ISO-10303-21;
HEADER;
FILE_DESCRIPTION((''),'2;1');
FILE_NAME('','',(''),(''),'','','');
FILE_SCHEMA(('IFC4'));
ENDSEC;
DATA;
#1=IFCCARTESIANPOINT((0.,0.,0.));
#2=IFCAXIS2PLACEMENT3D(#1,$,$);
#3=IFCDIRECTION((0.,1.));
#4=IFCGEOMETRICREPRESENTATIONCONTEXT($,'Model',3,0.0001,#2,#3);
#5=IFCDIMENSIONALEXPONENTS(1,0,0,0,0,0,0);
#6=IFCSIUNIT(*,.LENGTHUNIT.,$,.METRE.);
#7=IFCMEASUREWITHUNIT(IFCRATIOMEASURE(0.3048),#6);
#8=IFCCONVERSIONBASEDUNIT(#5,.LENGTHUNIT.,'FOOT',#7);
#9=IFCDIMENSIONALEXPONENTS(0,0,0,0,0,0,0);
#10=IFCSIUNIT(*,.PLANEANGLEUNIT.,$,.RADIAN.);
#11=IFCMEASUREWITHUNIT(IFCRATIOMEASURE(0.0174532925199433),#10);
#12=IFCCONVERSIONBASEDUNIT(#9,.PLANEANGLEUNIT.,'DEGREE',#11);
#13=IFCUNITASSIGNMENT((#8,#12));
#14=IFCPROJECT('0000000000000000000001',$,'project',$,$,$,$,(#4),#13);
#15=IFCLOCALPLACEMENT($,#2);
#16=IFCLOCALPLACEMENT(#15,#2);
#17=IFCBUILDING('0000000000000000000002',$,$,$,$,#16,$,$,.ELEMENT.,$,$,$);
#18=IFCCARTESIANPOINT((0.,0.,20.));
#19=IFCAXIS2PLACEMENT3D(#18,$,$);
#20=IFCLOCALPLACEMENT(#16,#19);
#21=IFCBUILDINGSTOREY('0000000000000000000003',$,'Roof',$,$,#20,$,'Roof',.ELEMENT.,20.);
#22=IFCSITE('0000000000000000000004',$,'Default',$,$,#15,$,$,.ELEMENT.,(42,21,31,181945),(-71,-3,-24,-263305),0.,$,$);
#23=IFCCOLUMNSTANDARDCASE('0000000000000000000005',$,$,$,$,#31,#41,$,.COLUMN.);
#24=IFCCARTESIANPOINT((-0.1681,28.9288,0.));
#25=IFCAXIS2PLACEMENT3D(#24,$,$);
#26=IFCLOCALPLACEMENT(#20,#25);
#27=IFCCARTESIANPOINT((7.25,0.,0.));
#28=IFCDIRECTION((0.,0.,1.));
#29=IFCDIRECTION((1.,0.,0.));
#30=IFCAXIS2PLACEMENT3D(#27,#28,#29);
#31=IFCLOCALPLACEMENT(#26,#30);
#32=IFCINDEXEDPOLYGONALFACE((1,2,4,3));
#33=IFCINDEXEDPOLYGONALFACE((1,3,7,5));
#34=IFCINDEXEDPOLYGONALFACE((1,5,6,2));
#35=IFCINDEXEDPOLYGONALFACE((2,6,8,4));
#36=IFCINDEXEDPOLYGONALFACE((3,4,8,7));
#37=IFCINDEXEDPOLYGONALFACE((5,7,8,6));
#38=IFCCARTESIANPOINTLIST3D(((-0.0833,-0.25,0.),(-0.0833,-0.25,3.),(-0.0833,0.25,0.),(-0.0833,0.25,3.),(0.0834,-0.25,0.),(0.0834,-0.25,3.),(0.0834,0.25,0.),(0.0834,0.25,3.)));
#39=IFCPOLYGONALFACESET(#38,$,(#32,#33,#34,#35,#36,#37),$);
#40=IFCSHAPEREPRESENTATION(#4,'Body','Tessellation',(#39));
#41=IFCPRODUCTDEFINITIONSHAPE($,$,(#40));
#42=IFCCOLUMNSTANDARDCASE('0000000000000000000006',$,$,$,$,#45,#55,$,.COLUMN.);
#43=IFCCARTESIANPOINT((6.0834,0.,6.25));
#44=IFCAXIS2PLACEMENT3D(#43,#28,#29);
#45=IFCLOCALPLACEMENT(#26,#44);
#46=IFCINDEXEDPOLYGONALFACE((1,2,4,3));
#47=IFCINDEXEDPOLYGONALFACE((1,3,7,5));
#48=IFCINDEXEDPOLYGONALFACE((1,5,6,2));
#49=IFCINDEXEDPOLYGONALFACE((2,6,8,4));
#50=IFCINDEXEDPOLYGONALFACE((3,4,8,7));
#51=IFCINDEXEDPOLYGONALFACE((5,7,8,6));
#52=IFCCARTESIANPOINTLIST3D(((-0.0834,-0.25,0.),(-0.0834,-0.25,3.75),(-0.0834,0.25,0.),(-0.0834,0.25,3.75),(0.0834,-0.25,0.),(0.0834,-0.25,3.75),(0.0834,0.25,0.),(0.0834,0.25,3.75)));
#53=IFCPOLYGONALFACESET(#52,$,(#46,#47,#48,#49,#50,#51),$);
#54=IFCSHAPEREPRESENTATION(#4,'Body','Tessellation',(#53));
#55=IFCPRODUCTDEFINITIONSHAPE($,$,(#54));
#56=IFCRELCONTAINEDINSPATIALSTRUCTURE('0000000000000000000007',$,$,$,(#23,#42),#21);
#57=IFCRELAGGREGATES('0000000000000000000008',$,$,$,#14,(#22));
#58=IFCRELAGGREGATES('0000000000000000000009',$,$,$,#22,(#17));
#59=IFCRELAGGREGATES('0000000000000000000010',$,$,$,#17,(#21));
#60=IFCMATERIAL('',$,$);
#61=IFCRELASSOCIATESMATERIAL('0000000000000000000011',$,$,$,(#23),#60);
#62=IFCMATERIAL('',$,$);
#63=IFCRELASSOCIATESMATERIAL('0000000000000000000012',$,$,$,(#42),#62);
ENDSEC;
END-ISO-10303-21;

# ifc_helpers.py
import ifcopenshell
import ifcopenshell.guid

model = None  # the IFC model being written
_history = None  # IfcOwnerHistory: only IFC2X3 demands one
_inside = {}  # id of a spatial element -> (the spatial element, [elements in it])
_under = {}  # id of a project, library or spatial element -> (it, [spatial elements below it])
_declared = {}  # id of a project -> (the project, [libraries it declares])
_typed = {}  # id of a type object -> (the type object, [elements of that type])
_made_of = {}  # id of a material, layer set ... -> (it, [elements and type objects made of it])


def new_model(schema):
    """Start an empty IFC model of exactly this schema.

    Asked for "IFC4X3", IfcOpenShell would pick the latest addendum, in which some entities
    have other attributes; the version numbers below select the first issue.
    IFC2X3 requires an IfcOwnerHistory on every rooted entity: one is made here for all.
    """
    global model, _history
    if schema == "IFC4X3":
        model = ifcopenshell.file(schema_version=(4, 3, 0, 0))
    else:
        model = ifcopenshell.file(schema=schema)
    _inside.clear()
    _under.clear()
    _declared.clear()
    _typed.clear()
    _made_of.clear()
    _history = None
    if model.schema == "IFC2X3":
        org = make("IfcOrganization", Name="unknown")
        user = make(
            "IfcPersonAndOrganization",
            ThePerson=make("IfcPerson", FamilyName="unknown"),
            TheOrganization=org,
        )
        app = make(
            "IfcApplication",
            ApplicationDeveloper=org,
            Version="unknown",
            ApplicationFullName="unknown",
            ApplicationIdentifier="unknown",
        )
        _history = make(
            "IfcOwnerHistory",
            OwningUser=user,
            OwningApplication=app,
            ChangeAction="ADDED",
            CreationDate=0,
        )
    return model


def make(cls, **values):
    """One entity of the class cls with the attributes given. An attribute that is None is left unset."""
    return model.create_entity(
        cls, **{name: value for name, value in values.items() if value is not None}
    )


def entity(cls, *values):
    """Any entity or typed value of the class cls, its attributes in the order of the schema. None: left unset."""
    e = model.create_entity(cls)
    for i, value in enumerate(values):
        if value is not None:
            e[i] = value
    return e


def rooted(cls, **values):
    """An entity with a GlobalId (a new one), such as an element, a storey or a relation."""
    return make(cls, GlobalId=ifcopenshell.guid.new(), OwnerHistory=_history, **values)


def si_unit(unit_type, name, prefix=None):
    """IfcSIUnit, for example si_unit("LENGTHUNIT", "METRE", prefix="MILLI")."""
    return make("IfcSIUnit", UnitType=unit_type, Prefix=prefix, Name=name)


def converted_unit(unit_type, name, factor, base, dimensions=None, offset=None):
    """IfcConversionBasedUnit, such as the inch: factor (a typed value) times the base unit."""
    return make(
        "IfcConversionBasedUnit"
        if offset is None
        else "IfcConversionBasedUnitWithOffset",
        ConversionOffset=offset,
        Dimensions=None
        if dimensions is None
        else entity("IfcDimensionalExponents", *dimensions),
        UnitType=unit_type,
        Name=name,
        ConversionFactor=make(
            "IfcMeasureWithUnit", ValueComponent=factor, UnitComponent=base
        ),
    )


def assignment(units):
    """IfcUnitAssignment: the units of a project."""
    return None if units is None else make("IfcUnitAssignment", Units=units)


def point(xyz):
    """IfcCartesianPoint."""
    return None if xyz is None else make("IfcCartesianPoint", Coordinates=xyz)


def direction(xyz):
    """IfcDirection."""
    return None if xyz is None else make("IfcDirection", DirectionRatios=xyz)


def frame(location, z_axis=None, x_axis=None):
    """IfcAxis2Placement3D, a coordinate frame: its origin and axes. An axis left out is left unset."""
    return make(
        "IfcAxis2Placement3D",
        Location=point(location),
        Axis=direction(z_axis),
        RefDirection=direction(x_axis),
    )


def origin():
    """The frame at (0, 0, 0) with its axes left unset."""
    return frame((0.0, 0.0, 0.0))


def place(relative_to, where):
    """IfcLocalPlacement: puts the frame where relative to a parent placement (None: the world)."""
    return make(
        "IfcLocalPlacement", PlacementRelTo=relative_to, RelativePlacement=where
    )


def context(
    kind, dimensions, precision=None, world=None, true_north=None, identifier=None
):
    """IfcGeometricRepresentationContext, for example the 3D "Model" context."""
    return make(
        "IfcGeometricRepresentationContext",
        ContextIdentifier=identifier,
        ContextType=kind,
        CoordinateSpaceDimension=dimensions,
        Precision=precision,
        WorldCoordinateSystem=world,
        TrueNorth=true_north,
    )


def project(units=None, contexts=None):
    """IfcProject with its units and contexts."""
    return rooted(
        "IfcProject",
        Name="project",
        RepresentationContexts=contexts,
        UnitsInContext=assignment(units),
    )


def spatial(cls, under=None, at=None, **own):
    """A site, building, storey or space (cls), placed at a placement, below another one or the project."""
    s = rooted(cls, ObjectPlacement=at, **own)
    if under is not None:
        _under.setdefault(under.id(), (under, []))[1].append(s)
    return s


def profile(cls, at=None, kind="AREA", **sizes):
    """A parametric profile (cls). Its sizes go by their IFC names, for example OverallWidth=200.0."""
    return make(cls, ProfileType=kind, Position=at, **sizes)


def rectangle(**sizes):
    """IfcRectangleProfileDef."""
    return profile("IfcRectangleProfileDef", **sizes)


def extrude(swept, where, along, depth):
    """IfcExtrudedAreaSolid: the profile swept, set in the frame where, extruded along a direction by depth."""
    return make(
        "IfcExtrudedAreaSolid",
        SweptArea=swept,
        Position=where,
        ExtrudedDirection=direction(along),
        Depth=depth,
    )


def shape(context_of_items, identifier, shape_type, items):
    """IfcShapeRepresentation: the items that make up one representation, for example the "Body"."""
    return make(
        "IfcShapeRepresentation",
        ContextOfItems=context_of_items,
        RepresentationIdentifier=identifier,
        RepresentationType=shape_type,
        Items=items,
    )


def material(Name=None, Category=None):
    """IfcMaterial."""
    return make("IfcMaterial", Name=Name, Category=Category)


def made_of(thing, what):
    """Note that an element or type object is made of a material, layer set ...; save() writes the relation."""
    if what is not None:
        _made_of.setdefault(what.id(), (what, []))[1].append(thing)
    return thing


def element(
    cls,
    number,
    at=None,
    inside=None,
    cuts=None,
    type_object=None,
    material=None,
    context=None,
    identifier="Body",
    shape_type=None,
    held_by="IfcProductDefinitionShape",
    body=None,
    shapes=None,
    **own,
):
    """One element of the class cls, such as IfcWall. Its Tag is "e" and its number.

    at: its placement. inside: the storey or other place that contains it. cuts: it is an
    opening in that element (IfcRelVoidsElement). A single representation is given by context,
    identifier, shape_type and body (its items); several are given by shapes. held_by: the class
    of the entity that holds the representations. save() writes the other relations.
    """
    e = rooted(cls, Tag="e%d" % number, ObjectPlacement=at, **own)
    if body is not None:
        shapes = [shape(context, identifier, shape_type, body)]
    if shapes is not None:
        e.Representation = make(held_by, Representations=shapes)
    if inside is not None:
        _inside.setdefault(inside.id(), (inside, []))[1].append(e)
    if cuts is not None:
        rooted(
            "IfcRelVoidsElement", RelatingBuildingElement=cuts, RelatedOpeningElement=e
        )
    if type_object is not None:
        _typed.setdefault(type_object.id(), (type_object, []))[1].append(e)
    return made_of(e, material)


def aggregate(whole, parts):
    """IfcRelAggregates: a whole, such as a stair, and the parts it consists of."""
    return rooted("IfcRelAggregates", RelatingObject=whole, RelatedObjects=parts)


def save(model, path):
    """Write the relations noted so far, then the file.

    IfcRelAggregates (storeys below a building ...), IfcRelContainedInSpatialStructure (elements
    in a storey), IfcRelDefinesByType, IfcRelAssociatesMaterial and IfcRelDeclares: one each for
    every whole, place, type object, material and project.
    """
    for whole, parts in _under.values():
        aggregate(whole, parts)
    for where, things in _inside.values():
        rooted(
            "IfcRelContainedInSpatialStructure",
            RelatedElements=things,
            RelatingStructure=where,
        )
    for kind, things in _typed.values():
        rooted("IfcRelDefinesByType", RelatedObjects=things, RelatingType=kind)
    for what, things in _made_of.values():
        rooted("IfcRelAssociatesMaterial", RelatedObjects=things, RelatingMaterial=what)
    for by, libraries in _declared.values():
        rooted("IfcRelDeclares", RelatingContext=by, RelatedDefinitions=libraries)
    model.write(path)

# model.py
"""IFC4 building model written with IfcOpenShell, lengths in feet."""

from ifc_helpers import new_model, entity, si_unit, converted_unit, direction, frame, origin, place, context, project, spatial, rectangle, extrude, material, element, save


model = new_model("IFC4")

# Units and contexts
model_context = context("Model", 3, precision=0.0001, world=origin(), true_north=direction((0.0, 1.0)))
ifc_project = project(units=[converted_unit("LENGTHUNIT", "FOOT", entity("IfcRatioMeasure", 0.3048), si_unit("LENGTHUNIT", "METRE"), dimensions=[1, 0, 0, 0, 0, 0, 0]), converted_unit("PLANEANGLEUNIT", "DEGREE", entity("IfcRatioMeasure", 0.0174532925199433), si_unit("PLANEANGLEUNIT", "RADIAN"), dimensions=[0, 0, 0, 0, 0, 0, 0])], contexts=[model_context])

# Site, building, storey
site_placement = place(None, origin())
site = spatial("IfcSite", under=ifc_project, at=site_placement, Name="Default", CompositionType="ELEMENT", RefLatitude=(42, 21, 31, 181945), RefLongitude=(-71, -3, -24, -263305), RefElevation=0.0)
building_placement = place(site_placement, origin())
building = spatial("IfcBuilding", under=site, at=building_placement, CompositionType="ELEMENT")
storey_placement = place(building_placement, frame((0.0, 0.0, 20.0)))
storey = spatial("IfcBuildingStorey", under=building, at=storey_placement, Name="Roof", LongName="Roof", CompositionType="ELEMENT", Elevation=20.0)

# Columns
ifc_material_1 = material(Name="")
placement = place(storey_placement, frame((-0.1681, 28.9288, 0.0)))
for number, where, z_axis, x_axis in (
    (1, (7.25, 0.0, 0.0), (0.0, 0.0, 1.0), (1.0, 0.0, 0.0)),
):
    element("IfcColumnStandardCase", number, at=place(placement, frame(where, z_axis=z_axis, x_axis=x_axis)), inside=storey, material=ifc_material_1, PredefinedType="COLUMN", context=model_context, shape_type="SweptSolid", body=[
        extrude(rectangle(XDim=0.1667, YDim=0.5), origin(), (0.0, 0.0, 1.0), 3.0),
    ])
ifc_material_2 = material(Name="")
for number, where, z_axis, x_axis in (
    (2, (6.0834, 0.0, 6.25), (0.0, 0.0, 1.0), (1.0, 0.0, 0.0)),
):
    element("IfcColumnStandardCase", number, at=place(placement, frame(where, z_axis=z_axis, x_axis=x_axis)), inside=storey, material=ifc_material_2, PredefinedType="COLUMN", context=model_context, shape_type="SweptSolid", body=[
        extrude(rectangle(XDim=0.1667, YDim=0.5), origin(), (0.0, 0.0, 1.0), 3.75),
    ])

save(model, "model.ifc")
